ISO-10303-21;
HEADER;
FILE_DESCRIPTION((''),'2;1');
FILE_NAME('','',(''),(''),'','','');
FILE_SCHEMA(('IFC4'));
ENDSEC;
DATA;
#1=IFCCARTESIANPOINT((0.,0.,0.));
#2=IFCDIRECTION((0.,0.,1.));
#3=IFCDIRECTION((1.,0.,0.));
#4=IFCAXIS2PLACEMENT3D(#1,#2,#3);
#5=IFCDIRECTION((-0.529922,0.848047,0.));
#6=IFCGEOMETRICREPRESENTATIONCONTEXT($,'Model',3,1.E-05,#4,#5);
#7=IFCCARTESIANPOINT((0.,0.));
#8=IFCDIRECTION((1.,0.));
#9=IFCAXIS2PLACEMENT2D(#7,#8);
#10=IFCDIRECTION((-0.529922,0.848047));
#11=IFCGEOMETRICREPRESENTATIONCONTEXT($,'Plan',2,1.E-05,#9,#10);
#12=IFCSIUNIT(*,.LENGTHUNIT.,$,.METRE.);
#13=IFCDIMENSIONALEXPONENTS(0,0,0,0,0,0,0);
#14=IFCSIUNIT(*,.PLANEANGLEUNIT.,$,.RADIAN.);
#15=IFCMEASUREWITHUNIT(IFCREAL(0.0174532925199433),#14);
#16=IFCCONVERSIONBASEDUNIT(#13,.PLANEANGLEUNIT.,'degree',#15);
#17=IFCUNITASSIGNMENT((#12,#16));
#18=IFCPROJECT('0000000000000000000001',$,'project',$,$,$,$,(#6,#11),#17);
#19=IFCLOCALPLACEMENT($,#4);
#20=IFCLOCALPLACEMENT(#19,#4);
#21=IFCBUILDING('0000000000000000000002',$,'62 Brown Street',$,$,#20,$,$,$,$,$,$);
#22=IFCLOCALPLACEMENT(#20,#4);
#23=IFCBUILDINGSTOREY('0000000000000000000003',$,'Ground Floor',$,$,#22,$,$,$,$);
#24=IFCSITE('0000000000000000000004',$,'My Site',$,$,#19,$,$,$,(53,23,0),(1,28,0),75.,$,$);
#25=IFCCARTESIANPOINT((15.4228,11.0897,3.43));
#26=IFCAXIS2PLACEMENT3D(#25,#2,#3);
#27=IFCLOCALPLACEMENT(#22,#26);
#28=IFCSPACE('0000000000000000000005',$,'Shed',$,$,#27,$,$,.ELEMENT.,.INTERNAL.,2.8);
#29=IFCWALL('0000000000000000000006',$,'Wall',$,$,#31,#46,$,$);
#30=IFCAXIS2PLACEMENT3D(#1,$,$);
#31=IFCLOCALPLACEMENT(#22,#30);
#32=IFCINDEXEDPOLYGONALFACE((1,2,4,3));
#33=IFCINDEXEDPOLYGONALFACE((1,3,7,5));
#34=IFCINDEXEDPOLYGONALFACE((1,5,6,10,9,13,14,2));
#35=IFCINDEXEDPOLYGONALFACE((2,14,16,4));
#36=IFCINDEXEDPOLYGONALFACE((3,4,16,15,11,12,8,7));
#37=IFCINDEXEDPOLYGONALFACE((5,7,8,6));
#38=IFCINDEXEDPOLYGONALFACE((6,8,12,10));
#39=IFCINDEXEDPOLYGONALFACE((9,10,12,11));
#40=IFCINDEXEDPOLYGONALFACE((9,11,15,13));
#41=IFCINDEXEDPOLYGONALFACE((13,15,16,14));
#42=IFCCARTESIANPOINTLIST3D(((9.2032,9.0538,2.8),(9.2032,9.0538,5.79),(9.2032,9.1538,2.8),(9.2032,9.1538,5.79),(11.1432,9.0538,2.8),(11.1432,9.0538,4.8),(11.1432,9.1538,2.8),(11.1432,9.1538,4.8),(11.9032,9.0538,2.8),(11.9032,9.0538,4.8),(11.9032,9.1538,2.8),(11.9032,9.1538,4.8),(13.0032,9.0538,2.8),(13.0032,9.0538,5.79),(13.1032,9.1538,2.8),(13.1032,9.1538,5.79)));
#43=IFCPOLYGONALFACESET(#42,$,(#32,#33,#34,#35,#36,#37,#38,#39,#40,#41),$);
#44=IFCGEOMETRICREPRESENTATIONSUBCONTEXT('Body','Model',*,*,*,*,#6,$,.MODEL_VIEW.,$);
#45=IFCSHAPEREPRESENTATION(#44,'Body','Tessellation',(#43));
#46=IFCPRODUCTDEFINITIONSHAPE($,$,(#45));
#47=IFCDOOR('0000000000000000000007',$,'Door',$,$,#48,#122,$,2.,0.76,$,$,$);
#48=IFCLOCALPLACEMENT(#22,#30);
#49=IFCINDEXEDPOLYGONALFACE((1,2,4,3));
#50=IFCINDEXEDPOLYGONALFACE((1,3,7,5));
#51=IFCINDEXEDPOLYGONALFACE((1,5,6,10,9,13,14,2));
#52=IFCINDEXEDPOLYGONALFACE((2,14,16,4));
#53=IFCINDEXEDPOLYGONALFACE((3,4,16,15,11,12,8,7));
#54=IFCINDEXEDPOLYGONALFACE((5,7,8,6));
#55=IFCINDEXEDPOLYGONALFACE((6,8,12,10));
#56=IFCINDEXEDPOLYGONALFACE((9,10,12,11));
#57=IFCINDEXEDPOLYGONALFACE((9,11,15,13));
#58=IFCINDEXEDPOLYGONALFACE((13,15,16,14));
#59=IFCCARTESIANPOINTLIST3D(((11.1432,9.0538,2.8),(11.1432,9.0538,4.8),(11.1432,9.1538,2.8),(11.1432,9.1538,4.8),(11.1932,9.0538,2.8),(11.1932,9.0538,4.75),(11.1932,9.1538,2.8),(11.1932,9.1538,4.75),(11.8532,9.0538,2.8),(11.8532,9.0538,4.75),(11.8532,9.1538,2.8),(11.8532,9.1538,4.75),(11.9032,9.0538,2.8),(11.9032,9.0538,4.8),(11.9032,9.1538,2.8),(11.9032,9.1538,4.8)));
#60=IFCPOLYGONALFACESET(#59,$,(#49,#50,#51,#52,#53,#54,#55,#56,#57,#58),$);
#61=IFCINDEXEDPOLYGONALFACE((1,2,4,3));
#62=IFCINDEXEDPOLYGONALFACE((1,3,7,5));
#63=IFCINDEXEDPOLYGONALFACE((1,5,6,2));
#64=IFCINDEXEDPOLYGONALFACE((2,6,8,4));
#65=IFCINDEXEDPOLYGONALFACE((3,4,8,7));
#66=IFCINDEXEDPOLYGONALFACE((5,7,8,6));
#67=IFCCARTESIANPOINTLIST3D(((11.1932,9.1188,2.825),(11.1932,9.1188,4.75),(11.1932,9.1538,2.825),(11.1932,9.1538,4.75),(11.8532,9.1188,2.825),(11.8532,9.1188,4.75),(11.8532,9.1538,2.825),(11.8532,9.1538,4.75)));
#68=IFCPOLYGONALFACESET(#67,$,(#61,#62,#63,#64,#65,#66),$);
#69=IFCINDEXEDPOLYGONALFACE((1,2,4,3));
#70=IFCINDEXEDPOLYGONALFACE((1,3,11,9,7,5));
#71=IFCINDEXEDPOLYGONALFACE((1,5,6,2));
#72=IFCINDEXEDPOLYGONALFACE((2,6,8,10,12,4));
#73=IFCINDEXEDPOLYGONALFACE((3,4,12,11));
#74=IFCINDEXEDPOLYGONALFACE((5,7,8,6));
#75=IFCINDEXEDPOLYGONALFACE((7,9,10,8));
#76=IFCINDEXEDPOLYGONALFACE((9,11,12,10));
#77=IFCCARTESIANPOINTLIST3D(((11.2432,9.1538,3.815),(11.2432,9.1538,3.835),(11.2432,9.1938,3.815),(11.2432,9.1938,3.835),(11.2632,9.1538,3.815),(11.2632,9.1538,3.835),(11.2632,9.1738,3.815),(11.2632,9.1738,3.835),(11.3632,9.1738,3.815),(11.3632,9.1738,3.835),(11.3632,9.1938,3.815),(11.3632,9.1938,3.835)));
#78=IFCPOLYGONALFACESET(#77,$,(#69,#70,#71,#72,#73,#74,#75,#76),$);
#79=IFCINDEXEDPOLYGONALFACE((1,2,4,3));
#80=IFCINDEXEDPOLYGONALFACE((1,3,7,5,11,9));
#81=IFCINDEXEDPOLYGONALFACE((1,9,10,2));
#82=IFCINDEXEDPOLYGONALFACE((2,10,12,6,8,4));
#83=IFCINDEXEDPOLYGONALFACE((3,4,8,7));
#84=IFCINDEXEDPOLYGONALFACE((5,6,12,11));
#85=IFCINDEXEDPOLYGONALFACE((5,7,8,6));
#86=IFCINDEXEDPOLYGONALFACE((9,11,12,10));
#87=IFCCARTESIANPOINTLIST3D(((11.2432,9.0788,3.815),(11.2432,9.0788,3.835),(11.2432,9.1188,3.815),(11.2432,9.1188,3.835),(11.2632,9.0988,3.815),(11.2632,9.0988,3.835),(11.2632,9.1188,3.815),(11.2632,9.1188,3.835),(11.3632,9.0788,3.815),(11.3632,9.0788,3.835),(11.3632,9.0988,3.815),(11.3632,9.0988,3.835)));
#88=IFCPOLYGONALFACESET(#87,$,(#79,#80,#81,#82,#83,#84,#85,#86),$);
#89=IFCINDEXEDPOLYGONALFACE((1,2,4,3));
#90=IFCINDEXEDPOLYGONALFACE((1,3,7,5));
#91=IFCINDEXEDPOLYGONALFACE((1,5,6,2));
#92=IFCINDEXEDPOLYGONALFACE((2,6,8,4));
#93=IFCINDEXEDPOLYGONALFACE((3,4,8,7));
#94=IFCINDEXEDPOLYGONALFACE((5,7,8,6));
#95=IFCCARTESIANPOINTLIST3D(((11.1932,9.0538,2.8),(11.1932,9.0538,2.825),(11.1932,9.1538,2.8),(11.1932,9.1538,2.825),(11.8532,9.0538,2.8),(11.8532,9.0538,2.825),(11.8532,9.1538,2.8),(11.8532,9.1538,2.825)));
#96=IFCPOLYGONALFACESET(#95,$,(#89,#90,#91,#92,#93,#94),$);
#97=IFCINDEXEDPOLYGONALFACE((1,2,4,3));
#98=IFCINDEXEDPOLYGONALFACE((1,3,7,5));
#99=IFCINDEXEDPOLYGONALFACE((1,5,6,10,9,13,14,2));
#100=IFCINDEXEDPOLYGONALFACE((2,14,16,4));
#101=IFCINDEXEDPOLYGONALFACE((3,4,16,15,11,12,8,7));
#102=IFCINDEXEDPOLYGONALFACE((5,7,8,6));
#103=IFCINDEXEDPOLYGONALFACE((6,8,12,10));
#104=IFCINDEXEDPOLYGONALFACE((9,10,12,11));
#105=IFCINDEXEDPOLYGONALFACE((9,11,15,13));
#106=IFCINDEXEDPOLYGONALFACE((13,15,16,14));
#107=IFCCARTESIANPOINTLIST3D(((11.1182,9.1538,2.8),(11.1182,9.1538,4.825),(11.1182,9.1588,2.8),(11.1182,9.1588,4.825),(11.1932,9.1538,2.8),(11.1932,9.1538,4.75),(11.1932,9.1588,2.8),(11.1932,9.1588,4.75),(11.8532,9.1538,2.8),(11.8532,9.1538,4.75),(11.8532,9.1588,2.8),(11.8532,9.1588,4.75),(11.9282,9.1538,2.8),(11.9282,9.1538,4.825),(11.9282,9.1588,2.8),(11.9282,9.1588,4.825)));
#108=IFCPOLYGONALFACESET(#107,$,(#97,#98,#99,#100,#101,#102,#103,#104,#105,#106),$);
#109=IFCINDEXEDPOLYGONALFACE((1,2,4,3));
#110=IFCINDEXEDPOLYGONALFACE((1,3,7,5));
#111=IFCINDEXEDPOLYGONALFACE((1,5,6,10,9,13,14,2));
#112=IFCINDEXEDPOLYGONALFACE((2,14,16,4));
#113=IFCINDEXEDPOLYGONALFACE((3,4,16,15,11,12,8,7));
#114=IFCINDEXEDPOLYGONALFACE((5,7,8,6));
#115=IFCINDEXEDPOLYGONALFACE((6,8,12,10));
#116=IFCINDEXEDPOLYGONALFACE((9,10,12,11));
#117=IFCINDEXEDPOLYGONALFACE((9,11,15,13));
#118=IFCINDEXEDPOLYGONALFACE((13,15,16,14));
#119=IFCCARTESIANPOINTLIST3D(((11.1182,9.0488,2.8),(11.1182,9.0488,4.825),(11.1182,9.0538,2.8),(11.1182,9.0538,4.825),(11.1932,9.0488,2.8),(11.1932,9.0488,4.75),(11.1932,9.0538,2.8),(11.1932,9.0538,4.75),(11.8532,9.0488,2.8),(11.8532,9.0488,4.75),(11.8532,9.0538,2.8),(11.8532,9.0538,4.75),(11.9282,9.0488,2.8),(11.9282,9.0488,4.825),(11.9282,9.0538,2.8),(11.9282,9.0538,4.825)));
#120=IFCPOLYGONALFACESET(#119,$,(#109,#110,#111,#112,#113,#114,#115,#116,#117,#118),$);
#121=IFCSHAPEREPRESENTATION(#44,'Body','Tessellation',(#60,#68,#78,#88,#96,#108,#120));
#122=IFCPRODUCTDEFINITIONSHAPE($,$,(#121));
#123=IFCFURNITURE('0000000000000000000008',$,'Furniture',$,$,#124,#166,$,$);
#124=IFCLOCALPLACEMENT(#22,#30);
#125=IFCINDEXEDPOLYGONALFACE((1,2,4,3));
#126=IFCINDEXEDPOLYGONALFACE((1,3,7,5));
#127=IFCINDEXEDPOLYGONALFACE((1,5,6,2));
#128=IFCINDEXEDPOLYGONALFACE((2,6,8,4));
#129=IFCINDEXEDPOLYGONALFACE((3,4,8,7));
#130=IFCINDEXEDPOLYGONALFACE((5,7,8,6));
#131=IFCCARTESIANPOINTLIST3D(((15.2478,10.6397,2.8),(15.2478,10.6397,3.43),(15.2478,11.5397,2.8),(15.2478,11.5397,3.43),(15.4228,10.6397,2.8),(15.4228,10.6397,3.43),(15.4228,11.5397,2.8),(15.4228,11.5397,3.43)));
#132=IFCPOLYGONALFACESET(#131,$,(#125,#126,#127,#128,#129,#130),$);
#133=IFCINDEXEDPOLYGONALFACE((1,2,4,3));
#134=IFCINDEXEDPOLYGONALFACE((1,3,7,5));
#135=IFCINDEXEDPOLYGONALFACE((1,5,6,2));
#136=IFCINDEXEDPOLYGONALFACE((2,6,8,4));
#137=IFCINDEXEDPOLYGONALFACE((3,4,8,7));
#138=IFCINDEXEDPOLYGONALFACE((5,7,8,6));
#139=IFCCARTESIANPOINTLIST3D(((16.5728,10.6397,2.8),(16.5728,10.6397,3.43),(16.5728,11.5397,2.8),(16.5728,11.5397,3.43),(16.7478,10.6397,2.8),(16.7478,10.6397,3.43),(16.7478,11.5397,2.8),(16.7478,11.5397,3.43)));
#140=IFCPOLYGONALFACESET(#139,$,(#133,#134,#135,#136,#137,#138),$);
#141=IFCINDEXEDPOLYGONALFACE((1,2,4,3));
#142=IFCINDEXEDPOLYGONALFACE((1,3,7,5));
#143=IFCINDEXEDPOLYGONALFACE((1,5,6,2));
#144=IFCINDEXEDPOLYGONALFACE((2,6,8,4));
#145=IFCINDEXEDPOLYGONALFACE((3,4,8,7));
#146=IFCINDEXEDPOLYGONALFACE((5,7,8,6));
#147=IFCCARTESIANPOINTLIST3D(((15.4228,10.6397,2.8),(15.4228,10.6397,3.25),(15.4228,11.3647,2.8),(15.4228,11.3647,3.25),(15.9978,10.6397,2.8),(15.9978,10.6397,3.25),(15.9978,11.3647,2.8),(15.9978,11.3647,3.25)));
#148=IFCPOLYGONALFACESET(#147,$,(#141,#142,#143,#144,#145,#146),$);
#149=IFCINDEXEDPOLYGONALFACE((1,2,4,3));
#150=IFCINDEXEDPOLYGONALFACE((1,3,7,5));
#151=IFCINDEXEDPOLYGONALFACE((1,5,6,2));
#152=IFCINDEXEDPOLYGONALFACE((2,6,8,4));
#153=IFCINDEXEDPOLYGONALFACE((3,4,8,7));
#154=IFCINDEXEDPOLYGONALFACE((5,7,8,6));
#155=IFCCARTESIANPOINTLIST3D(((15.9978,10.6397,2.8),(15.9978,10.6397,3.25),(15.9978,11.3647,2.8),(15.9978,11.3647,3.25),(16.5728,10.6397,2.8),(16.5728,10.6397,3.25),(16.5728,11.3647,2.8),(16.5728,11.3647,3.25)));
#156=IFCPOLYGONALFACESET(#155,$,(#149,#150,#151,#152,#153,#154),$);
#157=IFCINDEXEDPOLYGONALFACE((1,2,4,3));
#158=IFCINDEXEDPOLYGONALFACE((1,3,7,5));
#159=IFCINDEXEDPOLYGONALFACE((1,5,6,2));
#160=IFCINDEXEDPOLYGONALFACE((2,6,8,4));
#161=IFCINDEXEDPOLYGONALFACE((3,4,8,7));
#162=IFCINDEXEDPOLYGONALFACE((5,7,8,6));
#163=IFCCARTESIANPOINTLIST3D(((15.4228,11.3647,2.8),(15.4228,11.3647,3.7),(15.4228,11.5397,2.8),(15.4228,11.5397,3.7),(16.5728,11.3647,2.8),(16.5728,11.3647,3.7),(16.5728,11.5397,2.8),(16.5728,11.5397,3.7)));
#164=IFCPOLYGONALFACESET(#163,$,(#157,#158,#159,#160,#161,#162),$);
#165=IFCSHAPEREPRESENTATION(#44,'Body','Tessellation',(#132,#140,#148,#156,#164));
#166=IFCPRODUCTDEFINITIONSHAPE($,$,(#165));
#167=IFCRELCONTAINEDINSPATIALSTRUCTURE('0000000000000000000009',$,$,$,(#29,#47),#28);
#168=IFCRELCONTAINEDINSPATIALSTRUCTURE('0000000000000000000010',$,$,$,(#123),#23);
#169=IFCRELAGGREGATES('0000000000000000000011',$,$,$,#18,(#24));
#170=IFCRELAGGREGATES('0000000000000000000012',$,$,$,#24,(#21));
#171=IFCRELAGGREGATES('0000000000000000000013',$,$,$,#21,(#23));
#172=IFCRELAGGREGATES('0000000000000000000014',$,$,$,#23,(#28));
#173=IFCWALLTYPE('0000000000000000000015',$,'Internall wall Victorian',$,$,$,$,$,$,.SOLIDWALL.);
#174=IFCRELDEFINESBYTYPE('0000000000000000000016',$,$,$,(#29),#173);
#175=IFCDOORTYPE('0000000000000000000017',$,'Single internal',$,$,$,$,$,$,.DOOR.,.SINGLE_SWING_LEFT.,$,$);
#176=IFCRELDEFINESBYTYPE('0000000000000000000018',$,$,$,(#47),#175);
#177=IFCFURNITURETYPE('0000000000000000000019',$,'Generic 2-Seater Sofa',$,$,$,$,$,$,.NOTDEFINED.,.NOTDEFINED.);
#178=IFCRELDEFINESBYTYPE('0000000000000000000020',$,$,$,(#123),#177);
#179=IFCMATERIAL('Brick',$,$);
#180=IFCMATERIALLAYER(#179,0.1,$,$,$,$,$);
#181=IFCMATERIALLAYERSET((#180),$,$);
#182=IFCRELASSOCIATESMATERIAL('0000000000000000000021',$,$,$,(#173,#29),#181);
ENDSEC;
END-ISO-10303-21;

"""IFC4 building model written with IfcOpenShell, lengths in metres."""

from ifc_helpers import new_model, entity, si_unit, converted_unit, direction, frame, origin_with_axes, origin_2d_with_axis, place, context, subcontext, project, spatial, line, indexed_curve, outline, extrude, clip, halfspace, shape, source, transform, mapped, material, layer, layer_set, layer_usage, type_object, type_shapes, element, fill, save


model = new_model("IFC4")

# Units and contexts
model_context = context("Model", 3, precision=1e-05, world=origin_with_axes(), true_north=direction((-0.529922, 0.848047, 0.0)))
plan_context = context("Plan", 2, precision=1e-05, world=origin_2d_with_axis(), true_north=direction((-0.529922, 0.848047)))
body_context_1 = subcontext(model_context, "Body", "Model", "MODEL_VIEW")
body_context_2 = subcontext(plan_context, "Body", "Plan", "PLAN_VIEW")
ifc_project = project(units=[si_unit("LENGTHUNIT", "METRE"), converted_unit("PLANEANGLEUNIT", "degree", entity("IfcReal", 0.0174532925199433), si_unit("PLANEANGLEUNIT", "RADIAN"), dimensions=[0, 0, 0, 0, 0, 0, 0])], contexts=[model_context, plan_context])

# Site, building, storey
site_placement = place(None, origin_with_axes())
site = spatial("IfcSite", under=ifc_project, at=site_placement, Name="My Site", RefLatitude=(53, 23, 0), RefLongitude=(1, 28, 0), RefElevation=75.0)
building_placement = place(site_placement, origin_with_axes())
building = spatial("IfcBuilding", under=site, at=building_placement, Name="62 Brown Street")
storey_placement = place(building_placement, origin_with_axes())
storey = spatial("IfcBuildingStorey", under=building, at=storey_placement, Name="Ground Floor")

# Shared definitions
ifc_material_1 = material(Name="Brick")
ifc_layer_1 = layer(ifc_material_1, 0.1)
ifc_layer_set_1 = layer_set([ifc_layer_1])
wall_type_1 = type_object("IfcWallType", Name="Internall wall Victorian", PredefinedType="SOLIDWALL", material=ifc_layer_set_1)

# Shared definitions
space_1_placement = place(storey_placement, frame((15.4228, 11.0897, 3.43), z_axis=(0.0, 0.0, 1.0), x_axis=(1.0, 0.0, 0.0)))
space_1 = spatial("IfcSpace", under=storey, at=space_1_placement, Name="Shed", CompositionType="ELEMENT", PredefinedType="INTERNAL", ElevationWithFlooring=2.8)

# Wall, opening, door
ifc_layer_usage_1 = layer_usage(ifc_layer_set_1, "AXIS2", "POSITIVE", 0.0)
wall_1_placement = place(None, frame((13.1032, 9.1538, 2.8), z_axis=(0.0, 0.0, 1.0), x_axis=(-1.0, 0.0, 0.0)))
wall_1 = element("IfcWall", 1, at=wall_1_placement, inside=space_1, type_object=wall_type_1, material=ifc_layer_usage_1, Name="Wall", context=body_context_1, shape_type="Clipping", body=[
    clip(extrude(outline(indexed_curve([(0.0, 0.0), (0.0, 0.1), (3.9, 0.1), (3.9, 0.0), (0.0, 0.0)], self_intersect=False)), origin_with_axes(), (0.0, 0.0, 1.0), 2.99), halfspace(frame((0.0, 0.0, -2.8), z_axis=(-0.707104, 0.70711, 0.0), x_axis=(0.70711, 0.707104, 0.0)), False)),
])
shared_shape_1 = source(origin_with_axes(), body_context_1, "Body", "SweptSolid", [
    extrude(outline(indexed_curve([(0.0, 0.0), (0.76, 0.0), (0.76, 2.0), (0.0, 2.0)], segments=[line(1, 2, 3, 4, 1)])), frame((0.0, -0.6, 0.0), z_axis=(0.0, -1.0, 0.0), x_axis=(1.0, 0.0, 0.0)), (0.0, 0.0, -1.0), 1.2),
])
opening_placement = place(wall_1_placement, frame((1.2, 0.0, 0.0), z_axis=(0.0, 0.0, 1.0), x_axis=(1.0, 0.0, 0.0)))
opening = element("IfcOpeningElement", 2, at=opening_placement, cuts=wall_1, PredefinedType="OPENING", context=body_context_1, shape_type="MappedRepresentation", body=[
    mapped(shared_shape_1, transform((0.0, 0.0, 0.0), x_axis=(1.0, 0.0, 0.0), y_axis=(0.0, 1.0, 0.0), z_axis=(0.0, 0.0, 1.0), scale=1.0)),
])
door_type = type_object("IfcDoorType", Name="Single internal", OperationType="SINGLE_SWING_LEFT", PredefinedType="DOOR")
shared_shape_2 = source(origin_with_axes(), body_context_1, "Body", "SweptSolid", [
    extrude(outline(indexed_curve([(0.0, 0.0), (0.0, 2.0), (0.76, 2.0), (0.76, 0.0), (0.71, 0.0), (0.71, 1.95), (0.05, 1.95), (0.05, 0.0)], segments=[line(1, 2, 3, 4, 5, 6, 7, 8, 1)])), frame((0.0, 0.0, 0.0), z_axis=(0.0, -1.0, 0.0), x_axis=(1.0, 0.0, 0.0)), (0.0, 0.0, -1.0), 0.1),
    extrude(outline(indexed_curve([(0.0, 0.0), (0.66, 0.0), (0.66, 0.035), (0.0, 0.035)], segments=[line(1, 2, 3, 4, 1)])), frame((0.05, 0.0, 0.025), z_axis=(0.0, 0.0, 1.0), x_axis=(1.0, 0.0, 0.0)), (0.0, 0.0, 1.0), 1.925),
    extrude(outline(indexed_curve([(0.0, 0.0), (0.0, -0.04), (-0.12, -0.04), (-0.12, -0.02), (-0.02, -0.02), (-0.02, 0.0)], segments=[line(1, 2, 3, 4, 5, 6, 1)])), frame((0.66, 0.0, 1.015), z_axis=(0.0, 0.0, 1.0), x_axis=(1.0, 0.0, 0.0)), (0.0, 0.0, 1.0), 0.02),
    extrude(outline(indexed_curve([(0.0, 0.0), (0.0, 0.04), (-0.12, 0.04), (-0.12, 0.02), (-0.02, 0.02), (-0.02, 0.0)], segments=[line(1, 2, 3, 4, 5, 6, 1)])), frame((0.66, 0.035, 1.015), z_axis=(0.0, 0.0, 1.0), x_axis=(1.0, 0.0, 0.0)), (0.0, 0.0, 1.0), 0.02),
    extrude(outline(indexed_curve([(0.0, 0.0), (0.66, 0.0), (0.66, 0.1), (0.0, 0.1)], segments=[line(1, 2, 3, 4, 1)])), frame((0.05, 0.0, 0.0), z_axis=(0.0, 0.0, 1.0), x_axis=(1.0, 0.0, 0.0)), (0.0, 0.0, 1.0), 0.025),
    extrude(outline(indexed_curve([(0.0, 0.0), (0.0, 2.025), (0.81, 2.025), (0.81, 0.0), (0.735, 0.0), (0.735, 1.95), (0.075, 1.95), (0.075, 0.0)], segments=[line(1, 2, 3, 4, 5, 6, 7, 8, 1)])), frame((-0.025, -0.005, 0.0), z_axis=(0.0, -1.0, 0.0), x_axis=(1.0, 0.0, 0.0)), (0.0, 0.0, -1.0), 0.005),
    extrude(outline(indexed_curve([(0.0, 0.0), (0.0, 2.025), (0.81, 2.025), (0.81, 0.0), (0.735, 0.0), (0.735, 1.95), (0.075, 1.95), (0.075, 0.0)], segments=[line(1, 2, 3, 4, 5, 6, 7, 8, 1)])), frame((-0.025, 0.1, 0.0), z_axis=(0.0, -1.0, 0.0), x_axis=(1.0, 0.0, 0.0)), (0.0, 0.0, -1.0), 0.005),
])
shared_shape_3 = source(origin_with_axes(), body_context_2, "Body", "Curve2D", [
    entity("IfcIndexedPolyCurve", entity("IfcCartesianPointList2D", [[0.0, 0.0], [0.05, 0.0], [0.05, 0.1], [0.0, 0.1]]), [entity("IfcLineIndex", [1, 2, 3, 4, 1])]),
    entity("IfcIndexedPolyCurve", entity("IfcCartesianPointList2D", [[0.76, 0.0], [0.71, 0.0], [0.71, 0.1], [0.76, 0.1]]), [entity("IfcLineIndex", [1, 2, 3, 4, 1])]),
    entity("IfcTrimmedCurve", entity("IfcEllipse", entity("IfcAxis2Placement2D", entity("IfcCartesianPoint", [0.085, 0.1]), entity("IfcDirection", [1.0, 0.0])), 0.625, 0.66), [entity("IfcCartesianPoint", [0.71, 0.1])], [entity("IfcCartesianPoint", [0.085, 0.76])], True, "CARTESIAN"),
    entity("IfcIndexedPolyCurve", entity("IfcCartesianPointList2D", [[0.05, 0.1], [0.085, 0.1], [0.085, 0.76], [0.05, 0.76]]), [entity("IfcLineIndex", [1, 2, 3, 4, 1])]),
])
type_shapes(door_type, [shared_shape_2, shared_shape_3])
door_placement = place(opening_placement, frame((0.0, 0.0, 0.0), z_axis=(0.0, 0.0, 1.0), x_axis=(1.0, 0.0, 0.0)))
door = element("IfcDoor", 3, at=door_placement, inside=space_1, type_object=door_type, Name="Door", OverallHeight=2.0, OverallWidth=0.76, shapes=[
    shape(body_context_1, "Body", "MappedRepresentation", [mapped(shared_shape_2, transform((0.0, 0.0, 0.0), x_axis=(1.0, 0.0, 0.0), y_axis=(0.0, 1.0, 0.0), z_axis=(0.0, 0.0, 1.0), scale=1.0))]),
    shape(body_context_2, "Body", "MappedRepresentation", [mapped(shared_shape_3, transform((0.0, 0.0, 0.0), x_axis=(1.0, 0.0, 0.0), y_axis=(0.0, 1.0, 0.0), z_axis=(0.0, 0.0, 1.0), scale=1.0))]),
])
fill(opening, door)

# Furniture
furniture_type_1 = type_object("IfcFurnitureType", Name="Generic 2-Seater Sofa", AssemblyPlace="NOTDEFINED", PredefinedType="NOTDEFINED")
shared_shape_4 = source(origin_with_axes(), body_context_1, "Body", "SweptSolid", [
    extrude(outline(indexed_curve([(0.0, 0.0), (0.175, 0.0), (0.175, 0.9), (0.0, 0.9)], segments=[line(1, 2, 3, 4, 1)])), frame((-0.75, -0.9, 0.0), z_axis=(0.0, 0.0, 1.0), x_axis=(1.0, 0.0, 0.0)), (0.0, 0.0, 1.0), 0.63),
    extrude(outline(indexed_curve([(0.0, 0.0), (0.175, 0.0), (0.175, 0.9), (0.0, 0.9)], segments=[line(1, 2, 3, 4, 1)])), frame((0.575, -0.9, 0.0), z_axis=(0.0, 0.0, 1.0), x_axis=(1.0, 0.0, 0.0)), (0.0, 0.0, 1.0), 0.63),
    extrude(outline(indexed_curve([(0.175, 0.0), (0.75, 0.0), (0.75, 0.725), (0.175, 0.725)], segments=[line(1, 2, 3, 4, 1)])), frame((-0.75, -0.9, 0.0), z_axis=(0.0, 0.0, 1.0), x_axis=(1.0, 0.0, 0.0)), (0.0, 0.0, 1.0), 0.45),
    extrude(outline(indexed_curve([(0.75, 0.0), (1.325, 0.0), (1.325, 0.725), (0.75, 0.725)], segments=[line(1, 2, 3, 4, 1)])), frame((-0.75, -0.9, 0.0), z_axis=(0.0, 0.0, 1.0), x_axis=(1.0, 0.0, 0.0)), (0.0, 0.0, 1.0), 0.45),
    extrude(outline(indexed_curve([(0.175, 0.725), (1.325, 0.725), (1.325, 0.9), (0.175, 0.9)], segments=[line(1, 2, 3, 4, 1)])), frame((-0.75, -0.9, 0.0), z_axis=(0.0, 0.0, 1.0), x_axis=(1.0, 0.0, 0.0)), (0.0, 0.0, 1.0), 0.9),
])
shared_shape_5 = source(origin_with_axes(), body_context_2, "Body", "Curve2D", [
    entity("IfcIndexedPolyCurve", entity("IfcCartesianPointList2D", [[-0.75, -0.9], [-0.575, -0.9], [-0.575, 0.0], [-0.75, 0.0]]), [entity("IfcLineIndex", [1, 2, 3, 4, 1])]),
    entity("IfcIndexedPolyCurve", entity("IfcCartesianPointList2D", [[0.575, -0.9], [0.75, -0.9], [0.75, 0.0], [0.575, 0.0]]), [entity("IfcLineIndex", [1, 2, 3, 4, 1])]),
    entity("IfcIndexedPolyCurve", entity("IfcCartesianPointList2D", [[-0.575, -0.9], [0.0, -0.9], [0.0, -0.175], [-0.575, -0.175]]), [entity("IfcLineIndex", [1, 2, 3, 4, 1])]),
    entity("IfcIndexedPolyCurve", entity("IfcCartesianPointList2D", [[0.0, -0.9], [0.575, -0.9], [0.575, -0.175], [0.0, -0.175]]), [entity("IfcLineIndex", [1, 2, 3, 4, 1])]),
    entity("IfcIndexedPolyCurve", entity("IfcCartesianPointList2D", [[-0.575, -0.175], [0.575, -0.175], [0.575, 0.0], [-0.575, 0.0]]), [entity("IfcLineIndex", [1, 2, 3, 4, 1])]),
])
type_shapes(furniture_type_1, [shared_shape_4, shared_shape_5])
furniture_1_placement = place(storey_placement, frame((15.9978, 11.5397, 2.8), z_axis=(0.0, 0.0, 1.0), x_axis=(1.0, 0.0, 0.0)))
element("IfcFurniture", 4, at=furniture_1_placement, inside=storey, type_object=furniture_type_1, Name="Furniture", shapes=[
    shape(body_context_1, "Body", "MappedRepresentation", [mapped(shared_shape_4, transform((0.0, 0.0, 0.0), x_axis=(1.0, 0.0, 0.0), y_axis=(0.0, 1.0, 0.0), z_axis=(0.0, 0.0, 1.0), scale=1.0))]),
    shape(body_context_2, "Body", "MappedRepresentation", [mapped(shared_shape_5, transform((0.0, 0.0, 0.0), x_axis=(1.0, 0.0, 0.0), y_axis=(0.0, 1.0, 0.0), z_axis=(0.0, 0.0, 1.0), scale=1.0))]),
])

save(model, "model.ifc")
